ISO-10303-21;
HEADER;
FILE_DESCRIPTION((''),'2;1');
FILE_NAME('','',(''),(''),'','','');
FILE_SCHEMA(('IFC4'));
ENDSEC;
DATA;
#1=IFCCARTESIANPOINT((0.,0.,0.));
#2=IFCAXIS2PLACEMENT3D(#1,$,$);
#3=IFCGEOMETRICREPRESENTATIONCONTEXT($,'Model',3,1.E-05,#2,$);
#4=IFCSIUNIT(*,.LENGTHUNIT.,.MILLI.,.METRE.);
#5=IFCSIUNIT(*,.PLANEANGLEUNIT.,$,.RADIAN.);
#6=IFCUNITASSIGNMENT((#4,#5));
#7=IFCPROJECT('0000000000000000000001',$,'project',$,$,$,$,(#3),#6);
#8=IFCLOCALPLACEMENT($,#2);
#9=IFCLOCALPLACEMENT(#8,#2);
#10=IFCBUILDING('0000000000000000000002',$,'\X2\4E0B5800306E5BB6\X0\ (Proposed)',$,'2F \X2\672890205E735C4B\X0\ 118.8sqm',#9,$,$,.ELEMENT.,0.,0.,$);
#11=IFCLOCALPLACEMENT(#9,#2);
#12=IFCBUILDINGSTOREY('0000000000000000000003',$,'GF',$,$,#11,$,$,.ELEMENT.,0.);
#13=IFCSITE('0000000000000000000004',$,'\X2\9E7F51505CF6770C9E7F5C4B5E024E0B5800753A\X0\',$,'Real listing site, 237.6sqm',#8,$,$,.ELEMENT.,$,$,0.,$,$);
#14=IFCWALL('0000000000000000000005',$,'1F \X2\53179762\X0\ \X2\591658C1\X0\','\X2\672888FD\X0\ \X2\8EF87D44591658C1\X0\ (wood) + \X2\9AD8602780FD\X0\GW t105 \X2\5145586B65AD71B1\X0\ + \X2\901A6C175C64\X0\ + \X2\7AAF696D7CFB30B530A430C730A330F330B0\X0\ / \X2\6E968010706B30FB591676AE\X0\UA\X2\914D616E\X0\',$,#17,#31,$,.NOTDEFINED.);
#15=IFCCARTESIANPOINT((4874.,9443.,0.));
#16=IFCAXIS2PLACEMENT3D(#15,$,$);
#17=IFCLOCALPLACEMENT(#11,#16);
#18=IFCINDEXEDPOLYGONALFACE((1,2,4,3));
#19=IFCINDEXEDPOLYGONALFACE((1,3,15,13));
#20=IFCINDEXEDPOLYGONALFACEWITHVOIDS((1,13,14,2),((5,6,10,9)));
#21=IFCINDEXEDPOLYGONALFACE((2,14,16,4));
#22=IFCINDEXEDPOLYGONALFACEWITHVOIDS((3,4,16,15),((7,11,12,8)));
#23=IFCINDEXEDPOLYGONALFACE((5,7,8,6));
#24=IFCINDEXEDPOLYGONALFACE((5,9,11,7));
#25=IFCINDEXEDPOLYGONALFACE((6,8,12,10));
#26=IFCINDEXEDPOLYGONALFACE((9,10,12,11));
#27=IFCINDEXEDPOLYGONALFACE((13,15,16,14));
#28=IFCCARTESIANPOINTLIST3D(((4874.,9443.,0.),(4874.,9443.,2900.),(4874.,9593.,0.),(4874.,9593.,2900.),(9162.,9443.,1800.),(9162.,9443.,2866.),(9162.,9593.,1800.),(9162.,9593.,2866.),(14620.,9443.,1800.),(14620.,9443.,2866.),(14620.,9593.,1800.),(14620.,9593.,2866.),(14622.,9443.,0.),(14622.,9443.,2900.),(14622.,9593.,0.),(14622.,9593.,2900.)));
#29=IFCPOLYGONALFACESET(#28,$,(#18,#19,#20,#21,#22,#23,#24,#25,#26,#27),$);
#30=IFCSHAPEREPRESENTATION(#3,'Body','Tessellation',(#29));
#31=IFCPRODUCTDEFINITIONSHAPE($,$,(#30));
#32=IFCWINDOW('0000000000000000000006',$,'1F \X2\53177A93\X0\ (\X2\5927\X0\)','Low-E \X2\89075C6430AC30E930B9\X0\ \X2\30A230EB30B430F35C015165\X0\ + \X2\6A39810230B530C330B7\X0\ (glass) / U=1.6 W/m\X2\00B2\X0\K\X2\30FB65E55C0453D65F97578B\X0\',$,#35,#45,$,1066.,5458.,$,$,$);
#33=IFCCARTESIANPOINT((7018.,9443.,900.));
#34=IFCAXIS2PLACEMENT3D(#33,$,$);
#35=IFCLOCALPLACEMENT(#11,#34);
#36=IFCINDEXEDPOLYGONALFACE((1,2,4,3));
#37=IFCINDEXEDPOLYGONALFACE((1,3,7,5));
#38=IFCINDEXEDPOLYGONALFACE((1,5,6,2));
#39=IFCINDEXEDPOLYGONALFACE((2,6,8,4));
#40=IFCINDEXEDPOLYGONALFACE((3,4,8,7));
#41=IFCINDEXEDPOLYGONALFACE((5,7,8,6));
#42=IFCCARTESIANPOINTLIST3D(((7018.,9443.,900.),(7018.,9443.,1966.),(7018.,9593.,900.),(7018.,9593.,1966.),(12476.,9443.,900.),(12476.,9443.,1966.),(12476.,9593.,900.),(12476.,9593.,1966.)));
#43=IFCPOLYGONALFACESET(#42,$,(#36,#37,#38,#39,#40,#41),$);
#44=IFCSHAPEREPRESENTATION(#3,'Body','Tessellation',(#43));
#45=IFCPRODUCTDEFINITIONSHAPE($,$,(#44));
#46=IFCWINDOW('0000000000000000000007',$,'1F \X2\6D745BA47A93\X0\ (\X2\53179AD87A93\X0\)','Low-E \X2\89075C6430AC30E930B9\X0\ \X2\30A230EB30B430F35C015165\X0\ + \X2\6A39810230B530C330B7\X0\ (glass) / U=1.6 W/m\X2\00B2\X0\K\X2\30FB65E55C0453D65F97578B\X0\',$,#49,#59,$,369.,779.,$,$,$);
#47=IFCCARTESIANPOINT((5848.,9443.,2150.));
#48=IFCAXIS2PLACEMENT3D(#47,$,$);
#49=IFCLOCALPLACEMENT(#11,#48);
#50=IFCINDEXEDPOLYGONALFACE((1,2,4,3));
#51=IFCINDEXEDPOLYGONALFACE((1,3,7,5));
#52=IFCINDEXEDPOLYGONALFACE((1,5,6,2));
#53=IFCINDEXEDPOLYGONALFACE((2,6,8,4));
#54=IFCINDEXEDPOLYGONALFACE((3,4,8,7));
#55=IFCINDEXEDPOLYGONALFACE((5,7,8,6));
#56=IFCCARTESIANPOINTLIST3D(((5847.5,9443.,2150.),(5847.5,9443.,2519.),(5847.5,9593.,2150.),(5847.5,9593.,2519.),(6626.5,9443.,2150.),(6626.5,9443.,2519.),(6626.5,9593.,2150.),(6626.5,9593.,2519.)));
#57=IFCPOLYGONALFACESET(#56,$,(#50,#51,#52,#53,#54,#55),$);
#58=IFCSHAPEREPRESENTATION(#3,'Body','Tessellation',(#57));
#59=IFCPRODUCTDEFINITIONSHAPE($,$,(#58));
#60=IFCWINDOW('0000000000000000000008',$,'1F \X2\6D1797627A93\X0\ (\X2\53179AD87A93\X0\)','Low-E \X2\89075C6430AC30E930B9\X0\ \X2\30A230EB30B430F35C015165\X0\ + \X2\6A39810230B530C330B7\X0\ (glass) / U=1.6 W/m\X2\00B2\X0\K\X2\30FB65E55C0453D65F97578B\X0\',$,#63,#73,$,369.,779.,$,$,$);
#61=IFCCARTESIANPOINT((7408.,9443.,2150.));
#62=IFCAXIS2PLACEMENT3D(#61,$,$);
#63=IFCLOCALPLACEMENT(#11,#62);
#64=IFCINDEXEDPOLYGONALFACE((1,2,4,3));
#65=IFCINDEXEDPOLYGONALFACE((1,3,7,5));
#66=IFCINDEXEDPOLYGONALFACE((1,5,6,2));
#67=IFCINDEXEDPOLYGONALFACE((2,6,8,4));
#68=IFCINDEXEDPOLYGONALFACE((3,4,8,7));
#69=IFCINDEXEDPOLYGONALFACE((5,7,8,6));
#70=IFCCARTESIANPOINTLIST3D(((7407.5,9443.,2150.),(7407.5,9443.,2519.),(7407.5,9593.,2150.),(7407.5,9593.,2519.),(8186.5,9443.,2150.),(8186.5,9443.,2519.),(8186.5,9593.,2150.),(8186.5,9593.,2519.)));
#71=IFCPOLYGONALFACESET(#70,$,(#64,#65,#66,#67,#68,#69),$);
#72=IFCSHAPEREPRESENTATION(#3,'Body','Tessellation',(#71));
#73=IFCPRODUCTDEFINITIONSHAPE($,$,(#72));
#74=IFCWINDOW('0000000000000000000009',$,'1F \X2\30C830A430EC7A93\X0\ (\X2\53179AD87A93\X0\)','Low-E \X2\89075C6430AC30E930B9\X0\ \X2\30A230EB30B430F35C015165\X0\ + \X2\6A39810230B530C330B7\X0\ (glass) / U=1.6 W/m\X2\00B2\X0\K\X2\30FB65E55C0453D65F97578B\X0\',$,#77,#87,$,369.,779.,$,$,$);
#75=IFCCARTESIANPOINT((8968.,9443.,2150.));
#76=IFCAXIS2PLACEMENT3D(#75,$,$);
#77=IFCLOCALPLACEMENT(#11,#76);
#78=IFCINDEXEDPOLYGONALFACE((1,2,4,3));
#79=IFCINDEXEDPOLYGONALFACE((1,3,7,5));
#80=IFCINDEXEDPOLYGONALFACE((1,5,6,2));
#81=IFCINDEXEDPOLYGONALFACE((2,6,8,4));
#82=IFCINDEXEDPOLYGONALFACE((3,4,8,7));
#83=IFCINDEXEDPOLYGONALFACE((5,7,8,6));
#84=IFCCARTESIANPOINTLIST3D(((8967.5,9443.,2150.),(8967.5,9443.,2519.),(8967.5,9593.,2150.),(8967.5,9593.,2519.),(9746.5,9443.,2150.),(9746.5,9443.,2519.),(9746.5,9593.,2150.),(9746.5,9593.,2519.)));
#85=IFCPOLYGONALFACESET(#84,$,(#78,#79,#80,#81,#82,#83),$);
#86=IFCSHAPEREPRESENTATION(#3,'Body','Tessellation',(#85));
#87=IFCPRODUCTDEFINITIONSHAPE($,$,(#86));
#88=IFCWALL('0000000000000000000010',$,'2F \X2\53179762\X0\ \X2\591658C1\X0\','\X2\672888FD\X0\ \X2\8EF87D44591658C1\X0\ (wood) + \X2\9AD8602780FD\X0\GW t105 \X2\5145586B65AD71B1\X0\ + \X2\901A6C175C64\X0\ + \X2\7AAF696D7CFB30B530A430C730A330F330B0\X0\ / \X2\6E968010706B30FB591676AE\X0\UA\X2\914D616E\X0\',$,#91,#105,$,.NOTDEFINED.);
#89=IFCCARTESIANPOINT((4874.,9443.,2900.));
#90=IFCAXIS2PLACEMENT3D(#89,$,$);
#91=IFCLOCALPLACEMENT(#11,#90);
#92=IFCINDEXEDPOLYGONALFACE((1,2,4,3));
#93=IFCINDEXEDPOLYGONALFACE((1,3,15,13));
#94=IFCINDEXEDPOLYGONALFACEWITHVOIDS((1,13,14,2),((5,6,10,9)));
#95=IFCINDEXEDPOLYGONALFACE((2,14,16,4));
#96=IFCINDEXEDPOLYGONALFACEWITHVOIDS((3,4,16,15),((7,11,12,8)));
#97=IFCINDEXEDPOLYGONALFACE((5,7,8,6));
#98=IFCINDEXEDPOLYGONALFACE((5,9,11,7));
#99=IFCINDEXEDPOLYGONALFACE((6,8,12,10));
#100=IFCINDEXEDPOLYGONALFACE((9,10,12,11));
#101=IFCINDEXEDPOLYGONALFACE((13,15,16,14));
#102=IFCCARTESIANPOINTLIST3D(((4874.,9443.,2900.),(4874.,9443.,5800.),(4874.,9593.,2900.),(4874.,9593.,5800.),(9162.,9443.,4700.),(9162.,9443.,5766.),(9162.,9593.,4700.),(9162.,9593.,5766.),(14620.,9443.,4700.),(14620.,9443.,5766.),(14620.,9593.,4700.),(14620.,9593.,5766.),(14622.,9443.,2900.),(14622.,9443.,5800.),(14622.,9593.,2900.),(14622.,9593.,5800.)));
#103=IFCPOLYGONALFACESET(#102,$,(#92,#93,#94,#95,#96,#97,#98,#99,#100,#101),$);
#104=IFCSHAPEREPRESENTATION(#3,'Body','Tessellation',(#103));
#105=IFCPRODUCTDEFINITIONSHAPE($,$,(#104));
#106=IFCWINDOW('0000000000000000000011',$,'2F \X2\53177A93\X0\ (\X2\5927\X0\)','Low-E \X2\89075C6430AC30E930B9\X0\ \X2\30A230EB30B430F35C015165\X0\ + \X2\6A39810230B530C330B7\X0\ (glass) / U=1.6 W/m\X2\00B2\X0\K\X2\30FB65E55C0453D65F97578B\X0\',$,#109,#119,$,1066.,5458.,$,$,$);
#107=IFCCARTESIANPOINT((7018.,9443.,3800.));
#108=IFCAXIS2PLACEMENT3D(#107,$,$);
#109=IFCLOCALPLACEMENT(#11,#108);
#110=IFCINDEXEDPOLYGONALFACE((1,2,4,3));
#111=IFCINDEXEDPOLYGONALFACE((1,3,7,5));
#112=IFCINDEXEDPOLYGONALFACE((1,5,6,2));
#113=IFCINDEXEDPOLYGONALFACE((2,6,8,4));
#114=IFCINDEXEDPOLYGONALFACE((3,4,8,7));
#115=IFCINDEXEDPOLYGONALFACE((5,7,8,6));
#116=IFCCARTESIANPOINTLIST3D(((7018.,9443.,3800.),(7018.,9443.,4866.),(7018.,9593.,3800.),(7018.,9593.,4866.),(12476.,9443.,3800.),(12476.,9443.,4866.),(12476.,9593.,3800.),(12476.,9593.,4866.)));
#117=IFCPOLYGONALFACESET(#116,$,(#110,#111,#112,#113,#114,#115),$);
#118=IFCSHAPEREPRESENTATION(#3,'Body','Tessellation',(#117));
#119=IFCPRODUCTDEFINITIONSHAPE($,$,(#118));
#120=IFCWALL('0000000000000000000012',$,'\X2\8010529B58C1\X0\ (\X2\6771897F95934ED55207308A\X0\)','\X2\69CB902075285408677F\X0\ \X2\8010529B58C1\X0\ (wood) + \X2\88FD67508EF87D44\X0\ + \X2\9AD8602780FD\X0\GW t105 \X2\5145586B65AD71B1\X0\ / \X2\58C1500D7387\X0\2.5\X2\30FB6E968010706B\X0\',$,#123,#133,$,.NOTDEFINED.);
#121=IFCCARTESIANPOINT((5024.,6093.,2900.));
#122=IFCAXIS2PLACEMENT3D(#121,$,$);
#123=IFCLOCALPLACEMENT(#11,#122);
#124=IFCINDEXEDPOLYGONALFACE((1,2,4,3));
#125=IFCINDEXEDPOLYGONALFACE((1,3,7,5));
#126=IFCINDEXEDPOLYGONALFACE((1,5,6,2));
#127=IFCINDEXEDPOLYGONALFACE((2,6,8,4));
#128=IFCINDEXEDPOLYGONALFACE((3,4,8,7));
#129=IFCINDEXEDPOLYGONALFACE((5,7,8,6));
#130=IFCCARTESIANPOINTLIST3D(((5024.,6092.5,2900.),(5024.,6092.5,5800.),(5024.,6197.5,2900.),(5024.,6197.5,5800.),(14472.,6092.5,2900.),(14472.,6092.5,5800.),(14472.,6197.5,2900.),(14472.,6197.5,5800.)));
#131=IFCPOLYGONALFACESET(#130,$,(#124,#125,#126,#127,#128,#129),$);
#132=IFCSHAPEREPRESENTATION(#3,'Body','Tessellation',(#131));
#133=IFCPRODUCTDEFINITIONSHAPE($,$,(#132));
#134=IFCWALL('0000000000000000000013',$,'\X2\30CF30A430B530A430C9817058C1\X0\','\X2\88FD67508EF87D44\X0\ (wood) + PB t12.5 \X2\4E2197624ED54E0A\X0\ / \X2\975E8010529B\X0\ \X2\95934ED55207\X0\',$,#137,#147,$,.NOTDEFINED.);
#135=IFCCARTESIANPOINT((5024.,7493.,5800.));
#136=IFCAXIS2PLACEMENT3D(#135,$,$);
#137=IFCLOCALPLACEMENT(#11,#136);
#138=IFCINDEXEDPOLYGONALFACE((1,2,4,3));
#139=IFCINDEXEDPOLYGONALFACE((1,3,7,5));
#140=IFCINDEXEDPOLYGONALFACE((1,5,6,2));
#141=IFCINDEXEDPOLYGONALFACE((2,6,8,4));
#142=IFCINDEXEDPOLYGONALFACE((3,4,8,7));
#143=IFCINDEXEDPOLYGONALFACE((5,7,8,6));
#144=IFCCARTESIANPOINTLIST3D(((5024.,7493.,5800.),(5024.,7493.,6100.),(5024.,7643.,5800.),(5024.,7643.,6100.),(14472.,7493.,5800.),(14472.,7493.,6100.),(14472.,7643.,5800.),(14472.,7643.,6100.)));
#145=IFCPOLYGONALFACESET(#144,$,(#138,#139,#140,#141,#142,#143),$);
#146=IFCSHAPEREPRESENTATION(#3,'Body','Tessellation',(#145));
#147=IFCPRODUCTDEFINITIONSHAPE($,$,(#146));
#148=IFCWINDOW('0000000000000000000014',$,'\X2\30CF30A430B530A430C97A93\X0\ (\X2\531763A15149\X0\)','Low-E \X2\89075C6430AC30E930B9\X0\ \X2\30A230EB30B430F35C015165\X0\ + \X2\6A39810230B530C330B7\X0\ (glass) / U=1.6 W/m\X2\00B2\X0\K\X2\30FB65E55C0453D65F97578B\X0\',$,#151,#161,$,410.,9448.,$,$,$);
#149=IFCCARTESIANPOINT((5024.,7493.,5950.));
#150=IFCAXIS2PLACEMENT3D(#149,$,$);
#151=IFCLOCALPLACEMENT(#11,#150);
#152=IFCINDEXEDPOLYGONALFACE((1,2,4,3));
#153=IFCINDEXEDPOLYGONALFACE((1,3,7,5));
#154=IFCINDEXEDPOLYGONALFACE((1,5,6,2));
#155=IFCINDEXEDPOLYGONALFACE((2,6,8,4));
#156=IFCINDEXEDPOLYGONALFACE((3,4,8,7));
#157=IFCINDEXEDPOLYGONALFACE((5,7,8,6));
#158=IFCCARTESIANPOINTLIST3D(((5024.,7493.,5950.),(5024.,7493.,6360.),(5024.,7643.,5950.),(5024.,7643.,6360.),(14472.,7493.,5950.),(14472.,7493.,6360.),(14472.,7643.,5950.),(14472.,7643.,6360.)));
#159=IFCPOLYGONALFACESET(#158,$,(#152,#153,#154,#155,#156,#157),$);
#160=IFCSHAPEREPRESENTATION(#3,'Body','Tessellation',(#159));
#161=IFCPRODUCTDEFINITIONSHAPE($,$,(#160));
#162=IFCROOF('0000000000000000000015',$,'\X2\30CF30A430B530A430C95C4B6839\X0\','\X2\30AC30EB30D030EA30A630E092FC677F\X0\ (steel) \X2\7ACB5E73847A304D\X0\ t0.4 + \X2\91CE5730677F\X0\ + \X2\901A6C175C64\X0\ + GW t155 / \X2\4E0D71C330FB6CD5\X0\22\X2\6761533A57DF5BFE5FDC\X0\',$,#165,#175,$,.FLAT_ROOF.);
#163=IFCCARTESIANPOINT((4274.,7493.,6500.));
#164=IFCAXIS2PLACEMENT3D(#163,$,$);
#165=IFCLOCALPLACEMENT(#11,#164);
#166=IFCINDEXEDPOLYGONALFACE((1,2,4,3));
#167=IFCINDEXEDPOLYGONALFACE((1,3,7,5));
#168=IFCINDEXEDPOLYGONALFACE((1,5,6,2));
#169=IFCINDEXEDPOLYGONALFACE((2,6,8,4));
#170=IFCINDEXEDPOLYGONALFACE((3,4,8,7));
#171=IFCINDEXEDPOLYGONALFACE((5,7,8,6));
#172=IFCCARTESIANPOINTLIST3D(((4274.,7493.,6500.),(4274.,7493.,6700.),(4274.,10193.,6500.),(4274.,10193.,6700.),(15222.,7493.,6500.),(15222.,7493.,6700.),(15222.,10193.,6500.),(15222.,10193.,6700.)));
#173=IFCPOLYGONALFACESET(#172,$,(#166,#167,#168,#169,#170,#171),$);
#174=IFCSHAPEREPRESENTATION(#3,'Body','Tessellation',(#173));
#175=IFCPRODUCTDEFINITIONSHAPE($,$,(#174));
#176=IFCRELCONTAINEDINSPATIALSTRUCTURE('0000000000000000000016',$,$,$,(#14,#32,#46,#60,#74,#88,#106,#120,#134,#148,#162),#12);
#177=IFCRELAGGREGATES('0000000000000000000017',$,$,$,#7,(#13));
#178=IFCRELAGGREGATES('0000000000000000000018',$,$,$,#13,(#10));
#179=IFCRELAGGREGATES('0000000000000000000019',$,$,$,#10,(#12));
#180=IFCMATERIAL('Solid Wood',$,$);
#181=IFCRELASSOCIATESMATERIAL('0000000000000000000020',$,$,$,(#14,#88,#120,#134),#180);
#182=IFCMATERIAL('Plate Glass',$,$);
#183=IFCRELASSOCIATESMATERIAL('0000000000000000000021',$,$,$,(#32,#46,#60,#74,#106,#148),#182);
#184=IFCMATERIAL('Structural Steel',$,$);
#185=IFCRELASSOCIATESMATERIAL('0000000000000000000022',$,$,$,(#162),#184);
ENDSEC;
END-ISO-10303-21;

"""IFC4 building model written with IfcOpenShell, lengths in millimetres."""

from ifc_helpers import new_model, si_unit, frame, frame_2d, origin, place, context, project, spatial, rectangle, extrude, material, element, fill, save


model = new_model("IFC4")

# Units and contexts
model_context = context("Model", 3, precision=1e-05, world=origin())
ifc_project = project(units=[si_unit("LENGTHUNIT", "METRE", prefix="MILLI"), si_unit("PLANEANGLEUNIT", "RADIAN")], contexts=[model_context])

# Site, building, storey
site_placement = place(None, origin())
site = spatial("IfcSite", under=ifc_project, at=site_placement, Name="鹿児島県鹿屋市下堀町", ObjectType="Real listing site, 237.6sqm", CompositionType="ELEMENT", RefElevation=0.0)
building_placement = place(site_placement, origin())
building = spatial("IfcBuilding", under=site, at=building_placement, Name="下堀の家 (Proposed)", ObjectType="2F 木造平屋 118.8sqm", CompositionType="ELEMENT", ElevationOfRefHeight=0.0, ElevationOfTerrain=0.0)
storey_placement = place(building_placement, origin())
storey = spatial("IfcBuildingStorey", under=building, at=storey_placement, Name="GF", CompositionType="ELEMENT", Elevation=0.0)

# Wall, openings, windows
ifc_material_1 = material(Name="Solid Wood")
wall_1_placement = place(storey_placement, frame((4874.0, 9443.0, 0.0)))
wall_1 = element("IfcWall", 1, at=wall_1_placement, inside=storey, material=ifc_material_1, Name="1F 北面 外壁", Description="木製 軸組外壁 (wood) + 高性能GW t105 充填断熱 + 通気層 + 窯業系サイディング / 準耐火・外皮UA配慮", PredefinedType="NOTDEFINED", context=model_context, shape_type="SweptSolid", body=[
    extrude(rectangle(XDim=9748.0, YDim=150.0, at=frame_2d((4874.0, 75.0))), frame((4874.0, 9443.0, 0.0)), (0.0, 0.0, 1.0), 2900.0),
])
opening_1_placement = place(storey_placement, frame((7018.0, 9443.0, 900.0)))
opening_1 = element("IfcOpeningElement", 2, at=opening_1_placement, cuts=wall_1, PredefinedType="NOTDEFINED", context=model_context, shape_type="SweptSolid", body=[
    extrude(rectangle(XDim=5458.0, YDim=150.0, at=frame_2d((2729.0, 75.0))), frame((7018.0, 9443.0, 900.0)), (0.0, 0.0, 1.0), 1066.0),
])
opening_2_placement = place(storey_placement, frame((5848.0, 9443.0, 2150.0)))
opening_2 = element("IfcOpeningElement", 3, at=opening_2_placement, cuts=wall_1, PredefinedType="NOTDEFINED", context=model_context, shape_type="SweptSolid", body=[
    extrude(rectangle(XDim=779.0, YDim=150.0, at=frame_2d((389.0, 75.0))), frame((5848.0, 9443.0, 2150.0)), (0.0, 0.0, 1.0), 369.0),
])
opening_3_placement = place(storey_placement, frame((7408.0, 9443.0, 2150.0)))
opening_3 = element("IfcOpeningElement", 4, at=opening_3_placement, cuts=wall_1, PredefinedType="NOTDEFINED", context=model_context, shape_type="SweptSolid", body=[
    extrude(rectangle(XDim=779.0, YDim=150.0, at=frame_2d((389.0, 75.0))), frame((7408.0, 9443.0, 2150.0)), (0.0, 0.0, 1.0), 369.0),
])
opening_4_placement = place(storey_placement, frame((8968.0, 9443.0, 2150.0)))
opening_4 = element("IfcOpeningElement", 5, at=opening_4_placement, cuts=wall_1, PredefinedType="NOTDEFINED", context=model_context, shape_type="SweptSolid", body=[
    extrude(rectangle(XDim=779.0, YDim=150.0, at=frame_2d((389.0, 75.0))), frame((8968.0, 9443.0, 2150.0)), (0.0, 0.0, 1.0), 369.0),
])
ifc_material_2 = material(Name="Plate Glass")
window_1_placement = place(storey_placement, frame((7018.0, 9443.0, 900.0)))
window_1 = element("IfcWindow", 6, at=window_1_placement, inside=storey, material=ifc_material_2, Name="1F 北窓 (大)", Description="Low-E 複層ガラス アルゴン封入 + 樹脂サッシ (glass) / U=1.6 W/m²K・日射取得型", OverallHeight=1066.0, OverallWidth=5458.0, context=model_context, shape_type="SweptSolid", body=[
    extrude(rectangle(XDim=5458.0, YDim=150.0, at=frame_2d((2729.0, 75.0))), frame((7018.0, 9443.0, 900.0)), (0.0, 0.0, 1.0), 1066.0),
])
fill(opening_1, window_1)
window_2_placement = place(storey_placement, frame((5848.0, 9443.0, 2150.0)))
window_2 = element("IfcWindow", 7, at=window_2_placement, inside=storey, material=ifc_material_2, Name="1F 浴室窓 (北高窓)", Description="Low-E 複層ガラス アルゴン封入 + 樹脂サッシ (glass) / U=1.6 W/m²K・日射取得型", OverallHeight=369.0, OverallWidth=779.0, context=model_context, shape_type="SweptSolid", body=[
    extrude(rectangle(XDim=779.0, YDim=150.0, at=frame_2d((389.0, 75.0))), frame((5848.0, 9443.0, 2150.0)), (0.0, 0.0, 1.0), 369.0),
])
fill(opening_2, window_2)
window_3_placement = place(storey_placement, frame((7408.0, 9443.0, 2150.0)))
window_3 = element("IfcWindow", 8, at=window_3_placement, inside=storey, material=ifc_material_2, Name="1F 洗面窓 (北高窓)", Description="Low-E 複層ガラス アルゴン封入 + 樹脂サッシ (glass) / U=1.6 W/m²K・日射取得型", OverallHeight=369.0, OverallWidth=779.0, context=model_context, shape_type="SweptSolid", body=[
    extrude(rectangle(XDim=779.0, YDim=150.0, at=frame_2d((389.0, 75.0))), frame((7408.0, 9443.0, 2150.0)), (0.0, 0.0, 1.0), 369.0),
])
fill(opening_3, window_3)
window_4_placement = place(storey_placement, frame((8968.0, 9443.0, 2150.0)))
window_4 = element("IfcWindow", 9, at=window_4_placement, inside=storey, material=ifc_material_2, Name="1F トイレ窓 (北高窓)", Description="Low-E 複層ガラス アルゴン封入 + 樹脂サッシ (glass) / U=1.6 W/m²K・日射取得型", OverallHeight=369.0, OverallWidth=779.0, context=model_context, shape_type="SweptSolid", body=[
    extrude(rectangle(XDim=779.0, YDim=150.0, at=frame_2d((389.0, 75.0))), frame((8968.0, 9443.0, 2150.0)), (0.0, 0.0, 1.0), 369.0),
])
fill(opening_4, window_4)

# Wall, opening, window
wall_2_placement = place(storey_placement, frame((4874.0, 9443.0, 2900.0)))
wall_2 = element("IfcWall", 10, at=wall_2_placement, inside=storey, material=ifc_material_1, Name="2F 北面 外壁", Description="木製 軸組外壁 (wood) + 高性能GW t105 充填断熱 + 通気層 + 窯業系サイディング / 準耐火・外皮UA配慮", PredefinedType="NOTDEFINED", context=model_context, shape_type="SweptSolid", body=[
    extrude(rectangle(XDim=9748.0, YDim=150.0, at=frame_2d((4874.0, 75.0))), frame((4874.0, 9443.0, 2900.0)), (0.0, 0.0, 1.0), 2900.0),
])
opening_5_placement = place(storey_placement, frame((7018.0, 9443.0, 3800.0)))
opening_5 = element("IfcOpeningElement", 11, at=opening_5_placement, cuts=wall_2, PredefinedType="NOTDEFINED", context=model_context, shape_type="SweptSolid", body=[
    extrude(rectangle(XDim=5458.0, YDim=150.0, at=frame_2d((2729.0, 75.0))), frame((7018.0, 9443.0, 3800.0)), (0.0, 0.0, 1.0), 1066.0),
])
window_5_placement = place(storey_placement, frame((7018.0, 9443.0, 3800.0)))
window_5 = element("IfcWindow", 12, at=window_5_placement, inside=storey, material=ifc_material_2, Name="2F 北窓 (大)", Description="Low-E 複層ガラス アルゴン封入 + 樹脂サッシ (glass) / U=1.6 W/m²K・日射取得型", OverallHeight=1066.0, OverallWidth=5458.0, context=model_context, shape_type="SweptSolid", body=[
    extrude(rectangle(XDim=5458.0, YDim=150.0, at=frame_2d((2729.0, 75.0))), frame((7018.0, 9443.0, 3800.0)), (0.0, 0.0, 1.0), 1066.0),
])
fill(opening_5, window_5)

# Wall
wall_3_placement = place(storey_placement, frame((5024.0, 6093.0, 2900.0)))
element("IfcWall", 13, at=wall_3_placement, inside=storey, material=ifc_material_1, Name="耐力壁 (東西間仕切り)", Description="構造用合板 耐力壁 (wood) + 製材軸組 + 高性能GW t105 充填断熱 / 壁倍率2.5・準耐火", PredefinedType="NOTDEFINED", context=model_context, shape_type="SweptSolid", body=[
    extrude(rectangle(XDim=9448.0, YDim=105.0, at=frame_2d((4724.0, 52.0))), frame((5024.0, 6093.0, 2900.0)), (0.0, 0.0, 1.0), 2900.0),
])

# Wall, opening, window
wall_4_placement = place(storey_placement, frame((5024.0, 7493.0, 5800.0)))
wall_4 = element("IfcWall", 14, at=wall_4_placement, inside=storey, material=ifc_material_1, Name="ハイサイド腰壁", Description="製材軸組 (wood) + PB t12.5 両面仕上 / 非耐力 間仕切", PredefinedType="NOTDEFINED", context=model_context, shape_type="SweptSolid", body=[
    extrude(rectangle(XDim=9448.0, YDim=150.0, at=frame_2d((4724.0, 75.0))), frame((5024.0, 7493.0, 5800.0)), (0.0, 0.0, 1.0), 700.0),
])
opening_6_placement = place(storey_placement, frame((5024.0, 7493.0, 5950.0)))
opening_6 = element("IfcOpeningElement", 15, at=opening_6_placement, cuts=wall_4, PredefinedType="NOTDEFINED", context=model_context, shape_type="SweptSolid", body=[
    extrude(rectangle(XDim=9448.0, YDim=150.0, at=frame_2d((4724.0, 75.0))), frame((5024.0, 7493.0, 5950.0)), (0.0, 0.0, 1.0), 410.0),
])
window_6_placement = place(storey_placement, frame((5024.0, 7493.0, 5950.0)))
window_6 = element("IfcWindow", 16, at=window_6_placement, inside=storey, material=ifc_material_2, Name="ハイサイド窓 (北採光)", Description="Low-E 複層ガラス アルゴン封入 + 樹脂サッシ (glass) / U=1.6 W/m²K・日射取得型", OverallHeight=410.0, OverallWidth=9448.0, context=model_context, shape_type="SweptSolid", body=[
    extrude(rectangle(XDim=9448.0, YDim=150.0, at=frame_2d((4724.0, 75.0))), frame((5024.0, 7493.0, 5950.0)), (0.0, 0.0, 1.0), 410.0),
])
fill(opening_6, window_6)

# Roof
ifc_material_3 = material(Name="Structural Steel")
roof_placement = place(storey_placement, frame((4274.0, 7493.0, 6500.0)))
element("IfcRoof", 17, at=roof_placement, inside=storey, material=ifc_material_3, Name="ハイサイド屋根", Description="ガルバリウム鋼板 (steel) 立平葺き t0.4 + 野地板 + 通気層 + GW t155 / 不燃・法22条区域対応", PredefinedType="FLAT_ROOF", context=model_context, shape_type="SweptSolid", body=[
    extrude(rectangle(XDim=10948.0, YDim=2700.0, at=frame_2d((5474.0, 1350.0))), frame((4274.0, 7493.0, 6500.0)), (0.0, 0.0, 1.0), 200.0),
])

save(model, "model.ifc")
